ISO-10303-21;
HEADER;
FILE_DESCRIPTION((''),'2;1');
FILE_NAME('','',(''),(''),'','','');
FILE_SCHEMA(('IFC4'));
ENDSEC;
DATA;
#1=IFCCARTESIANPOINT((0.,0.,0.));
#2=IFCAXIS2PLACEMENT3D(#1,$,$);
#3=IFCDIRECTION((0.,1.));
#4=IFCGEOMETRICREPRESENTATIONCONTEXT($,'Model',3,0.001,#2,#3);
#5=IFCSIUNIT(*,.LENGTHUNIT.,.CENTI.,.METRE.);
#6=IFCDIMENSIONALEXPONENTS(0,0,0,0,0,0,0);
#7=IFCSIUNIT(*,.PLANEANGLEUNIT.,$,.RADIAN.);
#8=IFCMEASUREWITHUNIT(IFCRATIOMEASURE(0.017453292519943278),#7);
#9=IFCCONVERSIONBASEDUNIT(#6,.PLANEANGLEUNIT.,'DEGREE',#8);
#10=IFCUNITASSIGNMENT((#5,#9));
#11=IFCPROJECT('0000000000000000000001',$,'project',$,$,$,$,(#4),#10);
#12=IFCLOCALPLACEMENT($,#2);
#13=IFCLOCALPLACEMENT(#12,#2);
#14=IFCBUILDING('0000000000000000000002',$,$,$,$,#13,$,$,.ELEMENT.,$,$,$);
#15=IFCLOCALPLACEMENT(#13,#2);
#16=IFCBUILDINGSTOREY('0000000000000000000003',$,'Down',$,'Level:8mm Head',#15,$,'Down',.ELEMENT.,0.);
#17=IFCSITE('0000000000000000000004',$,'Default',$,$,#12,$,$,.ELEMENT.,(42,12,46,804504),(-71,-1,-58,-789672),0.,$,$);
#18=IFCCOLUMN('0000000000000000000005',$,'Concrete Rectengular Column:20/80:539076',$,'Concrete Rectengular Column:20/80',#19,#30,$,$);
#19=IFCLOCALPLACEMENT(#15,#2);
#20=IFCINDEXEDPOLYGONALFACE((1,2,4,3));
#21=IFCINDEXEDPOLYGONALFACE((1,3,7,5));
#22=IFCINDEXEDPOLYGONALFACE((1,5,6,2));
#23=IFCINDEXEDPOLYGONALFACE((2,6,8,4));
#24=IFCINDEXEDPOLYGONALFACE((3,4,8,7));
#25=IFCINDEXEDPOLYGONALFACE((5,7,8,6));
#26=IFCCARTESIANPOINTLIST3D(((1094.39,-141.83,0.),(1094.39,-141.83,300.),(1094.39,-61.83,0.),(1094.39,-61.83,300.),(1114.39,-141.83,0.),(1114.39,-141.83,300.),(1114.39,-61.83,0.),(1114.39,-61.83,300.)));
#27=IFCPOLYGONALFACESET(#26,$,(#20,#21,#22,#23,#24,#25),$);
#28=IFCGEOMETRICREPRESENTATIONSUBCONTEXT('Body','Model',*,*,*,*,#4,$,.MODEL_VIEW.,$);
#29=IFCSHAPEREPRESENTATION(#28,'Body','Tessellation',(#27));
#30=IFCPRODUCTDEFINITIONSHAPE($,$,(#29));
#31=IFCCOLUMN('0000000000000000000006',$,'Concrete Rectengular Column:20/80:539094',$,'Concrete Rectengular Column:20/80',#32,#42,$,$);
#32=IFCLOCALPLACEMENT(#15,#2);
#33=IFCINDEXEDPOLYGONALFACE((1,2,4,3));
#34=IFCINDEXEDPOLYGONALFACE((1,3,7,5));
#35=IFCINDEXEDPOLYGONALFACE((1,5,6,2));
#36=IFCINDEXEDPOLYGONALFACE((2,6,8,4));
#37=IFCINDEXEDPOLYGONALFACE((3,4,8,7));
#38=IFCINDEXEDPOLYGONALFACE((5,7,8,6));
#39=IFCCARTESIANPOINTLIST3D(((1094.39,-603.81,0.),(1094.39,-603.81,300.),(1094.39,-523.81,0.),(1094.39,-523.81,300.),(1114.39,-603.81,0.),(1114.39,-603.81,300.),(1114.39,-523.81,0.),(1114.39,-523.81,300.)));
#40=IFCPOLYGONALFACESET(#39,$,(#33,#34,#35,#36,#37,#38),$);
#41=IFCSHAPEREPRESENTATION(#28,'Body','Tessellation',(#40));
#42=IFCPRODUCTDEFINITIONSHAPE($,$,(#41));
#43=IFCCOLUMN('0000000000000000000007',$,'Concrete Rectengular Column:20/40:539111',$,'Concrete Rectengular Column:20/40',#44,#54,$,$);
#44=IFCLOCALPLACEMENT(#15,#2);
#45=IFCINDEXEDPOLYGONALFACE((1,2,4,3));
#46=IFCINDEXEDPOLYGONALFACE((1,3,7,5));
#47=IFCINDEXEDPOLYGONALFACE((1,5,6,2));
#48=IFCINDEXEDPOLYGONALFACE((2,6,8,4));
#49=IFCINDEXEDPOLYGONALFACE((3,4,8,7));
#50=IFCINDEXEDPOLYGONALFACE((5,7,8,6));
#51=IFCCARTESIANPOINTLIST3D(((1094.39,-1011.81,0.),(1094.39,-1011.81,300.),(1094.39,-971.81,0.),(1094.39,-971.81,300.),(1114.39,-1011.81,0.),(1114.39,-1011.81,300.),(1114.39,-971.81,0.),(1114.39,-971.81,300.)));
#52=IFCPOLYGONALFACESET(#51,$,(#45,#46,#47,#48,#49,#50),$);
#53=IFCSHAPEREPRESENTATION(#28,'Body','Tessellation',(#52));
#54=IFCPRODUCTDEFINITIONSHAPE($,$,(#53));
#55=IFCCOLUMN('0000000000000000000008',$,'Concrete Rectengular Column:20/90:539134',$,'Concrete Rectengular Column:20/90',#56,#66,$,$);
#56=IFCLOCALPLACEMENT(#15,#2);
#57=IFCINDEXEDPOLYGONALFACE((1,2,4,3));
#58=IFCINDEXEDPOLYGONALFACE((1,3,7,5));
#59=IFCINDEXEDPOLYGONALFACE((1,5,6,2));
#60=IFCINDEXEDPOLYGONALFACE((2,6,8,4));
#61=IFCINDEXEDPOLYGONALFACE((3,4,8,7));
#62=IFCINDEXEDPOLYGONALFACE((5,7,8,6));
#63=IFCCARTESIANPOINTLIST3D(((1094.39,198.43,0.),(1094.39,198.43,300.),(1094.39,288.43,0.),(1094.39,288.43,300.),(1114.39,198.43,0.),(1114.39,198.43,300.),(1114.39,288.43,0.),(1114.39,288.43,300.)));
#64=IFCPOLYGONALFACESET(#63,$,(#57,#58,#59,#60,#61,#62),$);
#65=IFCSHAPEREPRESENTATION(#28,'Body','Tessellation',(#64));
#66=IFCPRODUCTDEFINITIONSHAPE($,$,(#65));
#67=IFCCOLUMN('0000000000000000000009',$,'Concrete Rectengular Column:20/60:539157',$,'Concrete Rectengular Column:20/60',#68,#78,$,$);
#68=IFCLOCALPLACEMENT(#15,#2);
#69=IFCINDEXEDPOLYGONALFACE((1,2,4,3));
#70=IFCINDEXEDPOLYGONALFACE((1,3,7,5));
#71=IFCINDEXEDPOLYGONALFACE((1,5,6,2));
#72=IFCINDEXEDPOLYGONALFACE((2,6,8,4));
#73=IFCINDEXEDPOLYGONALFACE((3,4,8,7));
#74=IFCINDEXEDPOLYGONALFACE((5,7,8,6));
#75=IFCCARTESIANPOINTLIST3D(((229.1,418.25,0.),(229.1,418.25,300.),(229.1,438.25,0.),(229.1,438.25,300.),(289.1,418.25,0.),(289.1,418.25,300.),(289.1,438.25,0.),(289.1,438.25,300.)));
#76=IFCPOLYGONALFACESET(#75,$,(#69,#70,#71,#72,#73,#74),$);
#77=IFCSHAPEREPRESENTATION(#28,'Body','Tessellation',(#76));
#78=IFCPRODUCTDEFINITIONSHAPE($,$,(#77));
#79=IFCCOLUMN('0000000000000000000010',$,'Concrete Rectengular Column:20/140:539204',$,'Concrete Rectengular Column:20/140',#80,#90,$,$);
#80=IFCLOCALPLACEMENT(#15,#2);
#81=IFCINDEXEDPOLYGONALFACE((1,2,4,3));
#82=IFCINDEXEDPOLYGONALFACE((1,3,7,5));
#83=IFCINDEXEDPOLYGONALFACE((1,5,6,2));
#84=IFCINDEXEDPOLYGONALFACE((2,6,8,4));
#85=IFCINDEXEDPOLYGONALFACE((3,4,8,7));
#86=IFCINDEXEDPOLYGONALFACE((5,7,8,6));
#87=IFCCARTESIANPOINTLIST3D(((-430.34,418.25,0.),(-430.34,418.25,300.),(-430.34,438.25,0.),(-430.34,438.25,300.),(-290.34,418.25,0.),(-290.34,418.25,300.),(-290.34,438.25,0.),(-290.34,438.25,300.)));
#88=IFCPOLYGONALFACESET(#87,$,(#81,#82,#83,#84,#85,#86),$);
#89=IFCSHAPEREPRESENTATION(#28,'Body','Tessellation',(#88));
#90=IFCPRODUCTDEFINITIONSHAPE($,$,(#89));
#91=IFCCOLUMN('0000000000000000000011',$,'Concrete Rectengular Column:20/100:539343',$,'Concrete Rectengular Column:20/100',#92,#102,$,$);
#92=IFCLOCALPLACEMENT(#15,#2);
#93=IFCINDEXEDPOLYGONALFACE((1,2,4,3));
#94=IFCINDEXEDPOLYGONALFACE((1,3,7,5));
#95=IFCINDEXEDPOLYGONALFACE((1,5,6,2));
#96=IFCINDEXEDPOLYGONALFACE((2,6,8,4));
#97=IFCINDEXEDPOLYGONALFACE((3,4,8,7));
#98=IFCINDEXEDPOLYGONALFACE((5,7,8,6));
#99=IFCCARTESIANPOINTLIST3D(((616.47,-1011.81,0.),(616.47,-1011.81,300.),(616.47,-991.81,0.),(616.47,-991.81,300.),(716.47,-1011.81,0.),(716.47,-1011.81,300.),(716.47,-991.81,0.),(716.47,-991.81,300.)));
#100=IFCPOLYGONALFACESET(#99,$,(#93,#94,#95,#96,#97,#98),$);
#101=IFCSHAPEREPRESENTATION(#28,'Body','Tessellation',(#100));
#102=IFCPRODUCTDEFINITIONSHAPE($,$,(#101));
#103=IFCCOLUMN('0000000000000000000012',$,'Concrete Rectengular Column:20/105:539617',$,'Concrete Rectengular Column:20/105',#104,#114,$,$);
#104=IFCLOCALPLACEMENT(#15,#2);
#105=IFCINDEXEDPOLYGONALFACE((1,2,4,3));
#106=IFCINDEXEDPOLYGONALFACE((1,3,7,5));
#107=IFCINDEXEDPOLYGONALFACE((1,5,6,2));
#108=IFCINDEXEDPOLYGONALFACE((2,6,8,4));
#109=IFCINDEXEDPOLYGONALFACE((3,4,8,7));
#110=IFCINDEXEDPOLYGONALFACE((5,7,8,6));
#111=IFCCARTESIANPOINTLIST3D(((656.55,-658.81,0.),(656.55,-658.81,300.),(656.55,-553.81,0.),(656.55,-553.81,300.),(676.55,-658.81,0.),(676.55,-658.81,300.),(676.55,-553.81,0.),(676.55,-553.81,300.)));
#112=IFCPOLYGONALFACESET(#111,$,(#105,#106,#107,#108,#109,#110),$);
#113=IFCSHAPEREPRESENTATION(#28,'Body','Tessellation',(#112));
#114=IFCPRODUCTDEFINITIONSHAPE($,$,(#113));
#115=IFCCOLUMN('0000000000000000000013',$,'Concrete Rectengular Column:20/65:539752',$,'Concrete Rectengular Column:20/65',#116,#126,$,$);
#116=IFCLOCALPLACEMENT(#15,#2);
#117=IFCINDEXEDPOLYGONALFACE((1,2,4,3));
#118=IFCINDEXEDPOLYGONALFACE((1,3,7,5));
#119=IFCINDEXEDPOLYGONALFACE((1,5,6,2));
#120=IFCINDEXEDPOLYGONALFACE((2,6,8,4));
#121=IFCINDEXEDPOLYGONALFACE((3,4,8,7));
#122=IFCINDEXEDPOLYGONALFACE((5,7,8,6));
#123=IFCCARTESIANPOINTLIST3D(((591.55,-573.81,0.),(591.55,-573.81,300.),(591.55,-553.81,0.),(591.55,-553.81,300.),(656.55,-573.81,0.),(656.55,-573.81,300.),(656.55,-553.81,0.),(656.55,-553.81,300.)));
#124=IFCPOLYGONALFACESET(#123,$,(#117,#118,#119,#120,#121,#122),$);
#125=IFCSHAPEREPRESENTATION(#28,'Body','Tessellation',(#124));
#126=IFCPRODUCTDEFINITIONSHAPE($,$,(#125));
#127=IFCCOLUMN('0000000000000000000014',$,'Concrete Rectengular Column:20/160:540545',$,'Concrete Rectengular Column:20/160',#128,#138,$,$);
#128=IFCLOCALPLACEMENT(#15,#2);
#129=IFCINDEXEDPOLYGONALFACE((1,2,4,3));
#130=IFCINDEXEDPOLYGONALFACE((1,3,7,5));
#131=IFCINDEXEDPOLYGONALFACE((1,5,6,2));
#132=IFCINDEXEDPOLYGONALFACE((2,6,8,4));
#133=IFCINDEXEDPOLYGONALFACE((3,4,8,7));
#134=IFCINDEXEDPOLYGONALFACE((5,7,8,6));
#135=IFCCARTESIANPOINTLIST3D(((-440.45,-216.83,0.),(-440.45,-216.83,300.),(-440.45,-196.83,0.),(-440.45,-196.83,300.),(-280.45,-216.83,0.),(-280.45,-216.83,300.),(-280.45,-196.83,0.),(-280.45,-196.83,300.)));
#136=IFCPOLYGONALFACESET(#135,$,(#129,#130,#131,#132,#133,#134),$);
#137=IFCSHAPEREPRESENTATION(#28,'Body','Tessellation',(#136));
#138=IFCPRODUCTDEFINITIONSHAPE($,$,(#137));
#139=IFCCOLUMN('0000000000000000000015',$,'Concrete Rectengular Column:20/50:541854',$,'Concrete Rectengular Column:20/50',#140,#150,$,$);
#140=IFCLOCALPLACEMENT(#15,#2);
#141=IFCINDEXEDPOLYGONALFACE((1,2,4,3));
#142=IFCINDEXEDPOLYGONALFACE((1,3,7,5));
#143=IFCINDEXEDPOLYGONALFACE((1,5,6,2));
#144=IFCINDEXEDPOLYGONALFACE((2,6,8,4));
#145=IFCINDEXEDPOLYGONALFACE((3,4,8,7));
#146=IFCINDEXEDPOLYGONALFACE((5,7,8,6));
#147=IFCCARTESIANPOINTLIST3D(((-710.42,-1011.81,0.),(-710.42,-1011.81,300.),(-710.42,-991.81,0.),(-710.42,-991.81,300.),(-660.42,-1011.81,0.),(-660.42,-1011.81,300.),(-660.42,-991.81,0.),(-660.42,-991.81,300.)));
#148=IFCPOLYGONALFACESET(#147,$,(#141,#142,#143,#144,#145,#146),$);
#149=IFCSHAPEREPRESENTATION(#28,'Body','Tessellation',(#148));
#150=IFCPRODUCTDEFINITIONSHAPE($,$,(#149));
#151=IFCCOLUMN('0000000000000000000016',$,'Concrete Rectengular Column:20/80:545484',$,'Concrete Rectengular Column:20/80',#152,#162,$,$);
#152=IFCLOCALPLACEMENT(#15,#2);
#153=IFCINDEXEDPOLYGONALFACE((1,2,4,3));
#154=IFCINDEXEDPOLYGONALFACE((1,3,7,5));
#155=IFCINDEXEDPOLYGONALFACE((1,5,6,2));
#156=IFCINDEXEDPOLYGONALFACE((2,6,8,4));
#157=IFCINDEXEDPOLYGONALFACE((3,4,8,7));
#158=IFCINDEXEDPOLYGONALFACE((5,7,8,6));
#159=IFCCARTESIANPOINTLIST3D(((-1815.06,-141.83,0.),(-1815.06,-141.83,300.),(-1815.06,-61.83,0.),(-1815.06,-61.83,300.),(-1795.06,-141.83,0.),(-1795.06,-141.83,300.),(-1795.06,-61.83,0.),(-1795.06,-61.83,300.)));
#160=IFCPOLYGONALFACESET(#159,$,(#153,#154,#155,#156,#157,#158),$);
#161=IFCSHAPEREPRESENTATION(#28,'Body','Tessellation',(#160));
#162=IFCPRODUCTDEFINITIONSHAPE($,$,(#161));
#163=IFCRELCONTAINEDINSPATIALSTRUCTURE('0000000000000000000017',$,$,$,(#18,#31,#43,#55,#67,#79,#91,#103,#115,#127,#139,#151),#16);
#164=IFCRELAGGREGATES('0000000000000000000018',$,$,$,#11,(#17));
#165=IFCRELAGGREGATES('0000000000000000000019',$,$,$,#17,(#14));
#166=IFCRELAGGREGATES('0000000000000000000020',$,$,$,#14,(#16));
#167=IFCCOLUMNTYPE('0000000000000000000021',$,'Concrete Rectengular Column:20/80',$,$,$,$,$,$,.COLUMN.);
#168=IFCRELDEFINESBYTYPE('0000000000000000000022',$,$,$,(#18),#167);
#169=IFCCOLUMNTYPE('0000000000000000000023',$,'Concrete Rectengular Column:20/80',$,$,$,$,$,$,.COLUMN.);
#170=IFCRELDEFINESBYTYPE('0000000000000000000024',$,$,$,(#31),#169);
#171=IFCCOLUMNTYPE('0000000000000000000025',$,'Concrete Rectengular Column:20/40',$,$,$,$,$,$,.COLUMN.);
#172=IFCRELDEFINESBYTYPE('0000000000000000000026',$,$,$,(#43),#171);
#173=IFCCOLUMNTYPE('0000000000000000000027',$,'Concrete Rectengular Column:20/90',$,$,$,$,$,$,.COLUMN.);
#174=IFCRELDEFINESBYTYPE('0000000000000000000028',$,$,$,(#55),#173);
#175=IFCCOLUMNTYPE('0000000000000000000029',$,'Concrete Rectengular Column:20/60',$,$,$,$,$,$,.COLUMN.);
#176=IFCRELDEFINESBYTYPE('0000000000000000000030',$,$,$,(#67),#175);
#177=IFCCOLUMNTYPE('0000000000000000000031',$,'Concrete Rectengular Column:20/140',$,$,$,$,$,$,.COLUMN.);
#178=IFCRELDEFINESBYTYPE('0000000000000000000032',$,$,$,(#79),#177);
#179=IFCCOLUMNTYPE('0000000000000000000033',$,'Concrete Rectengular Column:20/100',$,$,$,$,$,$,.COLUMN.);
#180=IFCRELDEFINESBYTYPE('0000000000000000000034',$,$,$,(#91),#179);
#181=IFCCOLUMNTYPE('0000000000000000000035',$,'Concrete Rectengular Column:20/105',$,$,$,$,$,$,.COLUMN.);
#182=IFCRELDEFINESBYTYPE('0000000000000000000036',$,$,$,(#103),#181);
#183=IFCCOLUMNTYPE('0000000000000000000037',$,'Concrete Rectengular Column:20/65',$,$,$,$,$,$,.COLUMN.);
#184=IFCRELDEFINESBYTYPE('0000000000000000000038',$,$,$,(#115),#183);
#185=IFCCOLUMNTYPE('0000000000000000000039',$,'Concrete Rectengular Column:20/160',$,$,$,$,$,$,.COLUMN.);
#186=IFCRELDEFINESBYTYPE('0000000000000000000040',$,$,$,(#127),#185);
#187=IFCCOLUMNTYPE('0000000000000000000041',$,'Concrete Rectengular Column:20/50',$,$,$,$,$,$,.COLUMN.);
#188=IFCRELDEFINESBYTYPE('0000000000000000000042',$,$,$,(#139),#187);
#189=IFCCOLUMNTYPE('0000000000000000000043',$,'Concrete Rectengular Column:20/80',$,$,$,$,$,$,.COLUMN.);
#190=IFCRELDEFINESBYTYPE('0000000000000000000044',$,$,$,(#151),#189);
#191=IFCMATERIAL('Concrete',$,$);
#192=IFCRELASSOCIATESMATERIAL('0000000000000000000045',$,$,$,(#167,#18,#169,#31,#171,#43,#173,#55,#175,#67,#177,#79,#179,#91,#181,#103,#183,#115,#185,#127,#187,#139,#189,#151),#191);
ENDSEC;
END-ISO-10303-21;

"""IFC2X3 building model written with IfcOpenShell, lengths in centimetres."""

from ifc_helpers import new_model, entity, si_unit, converted_unit, direction, frame, frame_2d, origin, origin_2d_with_axis, place, context, subcontext, project, spatial, rectangle, extrude, source, transform, mapped, material, type_object, type_shapes, element, save


model = new_model("IFC2X3")

# Units and contexts
model_context = context("Model", 3, precision=0.001, world=origin(), true_north=direction((0.0, 1.0)))
body_context = subcontext(model_context, "Body", "Model", "MODEL_VIEW")
ifc_project = project(units=[si_unit("LENGTHUNIT", "METRE", prefix="CENTI"), converted_unit("PLANEANGLEUNIT", "DEGREE", entity("IfcRatioMeasure", 0.017453292519943278), si_unit("PLANEANGLEUNIT", "RADIAN"), dimensions=[0, 0, 0, 0, 0, 0, 0])], contexts=[model_context])

# Site, building, storey
site_placement = place(None, origin())
site = spatial("IfcSite", under=ifc_project, at=site_placement, Name="Default", CompositionType="ELEMENT", RefLatitude=(42, 12, 46, 804504), RefLongitude=(-71, -1, -58, -789672), RefElevation=0.0)
building_placement = place(site_placement, origin())
building = spatial("IfcBuilding", under=site, at=building_placement, CompositionType="ELEMENT")
storey_placement = place(building_placement, origin())
storey = spatial("IfcBuildingStorey", under=building, at=storey_placement, Name="Down", ObjectType="Level:8mm Head", LongName="Down", CompositionType="ELEMENT", Elevation=0.0)

# Columns
ifc_material = material(Name="Concrete")
column_type_1 = type_object("IfcColumnType", Name="Concrete Rectengular Column:20/80", PredefinedType="COLUMN", material=ifc_material)
shared_shape_1 = source(origin(), body_context, "Body", "SweptSolid", [
    extrude(rectangle(XDim=80.0, YDim=20.0, at=frame_2d((0.0, 0.0), x_axis=(1.0, 0.0))), frame((1104.39, -101.83, 0.0), z_axis=(0.0, 0.0, 1.0), x_axis=(0.0, -1.0, 0.0)), (0.0, 0.0, 1.0), 300.0),
])
type_shapes(column_type_1, [shared_shape_1])
column_1_placement = place(storey_placement, origin())
element("IfcColumn", 1, at=column_1_placement, inside=storey, type_object=column_type_1, material=ifc_material, Name="Concrete Rectengular Column:20/80:539076", ObjectType="Concrete Rectengular Column:20/80", context=body_context, shape_type="MappedRepresentation", body=[
    mapped(shared_shape_1, transform((0.0, 0.0, 0.0), scale=1.0)),
])
column_type_2 = type_object("IfcColumnType", Name="Concrete Rectengular Column:20/80", PredefinedType="COLUMN", material=ifc_material)
shared_shape_2 = source(origin(), body_context, "Body", "SweptSolid", [
    extrude(rectangle(XDim=80.0, YDim=20.0, at=frame_2d((0.0, 0.0), x_axis=(1.0, 0.0))), frame((1104.39, -563.81, 0.0), z_axis=(0.0, 0.0, 1.0), x_axis=(0.0, -1.0, 0.0)), (0.0, 0.0, 1.0), 300.0),
])
type_shapes(column_type_2, [shared_shape_2])
column_2_placement = place(storey_placement, origin())
element("IfcColumn", 2, at=column_2_placement, inside=storey, type_object=column_type_2, material=ifc_material, Name="Concrete Rectengular Column:20/80:539094", ObjectType="Concrete Rectengular Column:20/80", context=body_context, shape_type="MappedRepresentation", body=[
    mapped(shared_shape_2, transform((0.0, 0.0, 0.0), scale=1.0)),
])
column_type_3 = type_object("IfcColumnType", Name="Concrete Rectengular Column:20/40", PredefinedType="COLUMN", material=ifc_material)
shared_shape_3 = source(origin(), body_context, "Body", "SweptSolid", [
    extrude(rectangle(XDim=40.0, YDim=20.0, at=frame_2d((0.0, 0.0), x_axis=(1.0, 0.0))), frame((1104.39, -991.81, 0.0), z_axis=(0.0, 0.0, 1.0), x_axis=(0.0, -1.0, 0.0)), (0.0, 0.0, 1.0), 300.0),
])
type_shapes(column_type_3, [shared_shape_3])
column_3_placement = place(storey_placement, origin())
element("IfcColumn", 3, at=column_3_placement, inside=storey, type_object=column_type_3, material=ifc_material, Name="Concrete Rectengular Column:20/40:539111", ObjectType="Concrete Rectengular Column:20/40", context=body_context, shape_type="MappedRepresentation", body=[
    mapped(shared_shape_3, transform((0.0, 0.0, 0.0), scale=1.0)),
])
column_type_4 = type_object("IfcColumnType", Name="Concrete Rectengular Column:20/90", PredefinedType="COLUMN", material=ifc_material)
shared_shape_4 = source(origin(), body_context, "Body", "SweptSolid", [
    extrude(rectangle(XDim=90.0, YDim=20.0, at=frame_2d((0.0, 0.0), x_axis=(1.0, 0.0))), frame((1104.39, 243.43, 0.0), z_axis=(0.0, 0.0, 1.0), x_axis=(0.0, -1.0, 0.0)), (0.0, 0.0, 1.0), 300.0),
])
type_shapes(column_type_4, [shared_shape_4])
column_4_placement = place(storey_placement, origin())
element("IfcColumn", 4, at=column_4_placement, inside=storey, type_object=column_type_4, material=ifc_material, Name="Concrete Rectengular Column:20/90:539134", ObjectType="Concrete Rectengular Column:20/90", context=body_context, shape_type="MappedRepresentation", body=[
    mapped(shared_shape_4, transform((0.0, 0.0, 0.0), scale=1.0)),
])
column_type_5 = type_object("IfcColumnType", Name="Concrete Rectengular Column:20/60", PredefinedType="COLUMN", material=ifc_material)
shared_shape_5 = source(origin(), body_context, "Body", "SweptSolid", [
    extrude(rectangle(XDim=20.0, YDim=60.0, at=frame_2d((0.0, 0.0), x_axis=(1.0, 0.0))), frame((259.1, 428.25, 0.0), z_axis=(0.0, 0.0, 1.0), x_axis=(0.0, -1.0, 0.0)), (0.0, 0.0, 1.0), 300.0),
])
type_shapes(column_type_5, [shared_shape_5])
column_5_placement = place(storey_placement, origin())
element("IfcColumn", 5, at=column_5_placement, inside=storey, type_object=column_type_5, material=ifc_material, Name="Concrete Rectengular Column:20/60:539157", ObjectType="Concrete Rectengular Column:20/60", context=body_context, shape_type="MappedRepresentation", body=[
    mapped(shared_shape_5, transform((0.0, 0.0, 0.0), scale=1.0)),
])
column_type_6 = type_object("IfcColumnType", Name="Concrete Rectengular Column:20/140", PredefinedType="COLUMN", material=ifc_material)
shared_shape_6 = source(origin(), body_context, "Body", "SweptSolid", [
    extrude(rectangle(XDim=20.0, YDim=140.0, at=origin_2d_with_axis()), frame((-360.34, 428.25, 0.0), z_axis=(0.0, 0.0, 1.0), x_axis=(0.0, -1.0, 0.0)), (0.0, 0.0, 1.0), 300.0),
])
type_shapes(column_type_6, [shared_shape_6])
column_6_placement = place(storey_placement, origin())
element("IfcColumn", 6, at=column_6_placement, inside=storey, type_object=column_type_6, material=ifc_material, Name="Concrete Rectengular Column:20/140:539204", ObjectType="Concrete Rectengular Column:20/140", context=body_context, shape_type="MappedRepresentation", body=[
    mapped(shared_shape_6, transform((0.0, 0.0, 0.0), scale=1.0)),
])
column_type_7 = type_object("IfcColumnType", Name="Concrete Rectengular Column:20/100", PredefinedType="COLUMN", material=ifc_material)
shared_shape_7 = source(origin(), body_context, "Body", "SweptSolid", [
    extrude(rectangle(XDim=20.0, YDim=100.0, at=frame_2d((0.0, 0.0), x_axis=(1.0, 0.0))), frame((666.47, -1001.81, 0.0), z_axis=(0.0, 0.0, 1.0), x_axis=(0.0, -1.0, 0.0)), (0.0, 0.0, 1.0), 300.0),
])
type_shapes(column_type_7, [shared_shape_7])
column_7_placement = place(storey_placement, origin())
element("IfcColumn", 7, at=column_7_placement, inside=storey, type_object=column_type_7, material=ifc_material, Name="Concrete Rectengular Column:20/100:539343", ObjectType="Concrete Rectengular Column:20/100", context=body_context, shape_type="MappedRepresentation", body=[
    mapped(shared_shape_7, transform((0.0, 0.0, 0.0), scale=1.0)),
])
column_type_8 = type_object("IfcColumnType", Name="Concrete Rectengular Column:20/105", PredefinedType="COLUMN", material=ifc_material)
shared_shape_8 = source(origin(), body_context, "Body", "SweptSolid", [
    extrude(rectangle(XDim=105.0, YDim=20.0, at=origin_2d_with_axis()), frame((666.55, -606.31, 0.0), z_axis=(0.0, 0.0, 1.0), x_axis=(0.0, -1.0, 0.0)), (0.0, 0.0, 1.0), 300.0),
])
type_shapes(column_type_8, [shared_shape_8])
column_8_placement = place(storey_placement, origin())
element("IfcColumn", 8, at=column_8_placement, inside=storey, type_object=column_type_8, material=ifc_material, Name="Concrete Rectengular Column:20/105:539617", ObjectType="Concrete Rectengular Column:20/105", context=body_context, shape_type="MappedRepresentation", body=[
    mapped(shared_shape_8, transform((0.0, 0.0, 0.0), scale=1.0)),
])
column_type_9 = type_object("IfcColumnType", Name="Concrete Rectengular Column:20/65", PredefinedType="COLUMN", material=ifc_material)
shared_shape_9 = source(origin(), body_context, "Body", "SweptSolid", [
    extrude(rectangle(XDim=20.0, YDim=65.0, at=origin_2d_with_axis()), frame((624.05, -563.81, 0.0), z_axis=(0.0, 0.0, 1.0), x_axis=(0.0, -1.0, 0.0)), (0.0, 0.0, 1.0), 300.0),
])
type_shapes(column_type_9, [shared_shape_9])
column_9_placement = place(storey_placement, origin())
element("IfcColumn", 9, at=column_9_placement, inside=storey, type_object=column_type_9, material=ifc_material, Name="Concrete Rectengular Column:20/65:539752", ObjectType="Concrete Rectengular Column:20/65", context=body_context, shape_type="MappedRepresentation", body=[
    mapped(shared_shape_9, transform((0.0, 0.0, 0.0), scale=1.0)),
])
column_type_10 = type_object("IfcColumnType", Name="Concrete Rectengular Column:20/160", PredefinedType="COLUMN", material=ifc_material)
shared_shape_10 = source(origin(), body_context, "Body", "SweptSolid", [
    extrude(rectangle(XDim=20.0, YDim=160.0, at=origin_2d_with_axis()), frame((-360.45, -206.83, 0.0), z_axis=(0.0, 0.0, 1.0), x_axis=(0.0, -1.0, 0.0)), (0.0, 0.0, 1.0), 300.0),
])
type_shapes(column_type_10, [shared_shape_10])
column_10_placement = place(storey_placement, origin())
element("IfcColumn", 10, at=column_10_placement, inside=storey, type_object=column_type_10, material=ifc_material, Name="Concrete Rectengular Column:20/160:540545", ObjectType="Concrete Rectengular Column:20/160", context=body_context, shape_type="MappedRepresentation", body=[
    mapped(shared_shape_10, transform((0.0, 0.0, 0.0), scale=1.0)),
])
column_type_11 = type_object("IfcColumnType", Name="Concrete Rectengular Column:20/50", PredefinedType="COLUMN", material=ifc_material)
shared_shape_11 = source(origin(), body_context, "Body", "SweptSolid", [
    extrude(rectangle(XDim=20.0, YDim=50.0, at=frame_2d((0.0, 0.0), x_axis=(1.0, 0.0))), frame((-685.42, -1001.81, 0.0), z_axis=(0.0, 0.0, 1.0), x_axis=(0.0, -1.0, 0.0)), (0.0, 0.0, 1.0), 300.0),
])
type_shapes(column_type_11, [shared_shape_11])
column_11_placement = place(storey_placement, origin())
element("IfcColumn", 11, at=column_11_placement, inside=storey, type_object=column_type_11, material=ifc_material, Name="Concrete Rectengular Column:20/50:541854", ObjectType="Concrete Rectengular Column:20/50", context=body_context, shape_type="MappedRepresentation", body=[
    mapped(shared_shape_11, transform((0.0, 0.0, 0.0), scale=1.0)),
])
column_type_12 = type_object("IfcColumnType", Name="Concrete Rectengular Column:20/80", PredefinedType="COLUMN", material=ifc_material)
shared_shape_12 = source(origin(), body_context, "Body", "SweptSolid", [
    extrude(rectangle(XDim=80.0, YDim=20.0, at=frame_2d((0.0, 0.0), x_axis=(1.0, 0.0))), frame((-1805.06, -101.83, 0.0), z_axis=(0.0, 0.0, 1.0), x_axis=(0.0, -1.0, 0.0)), (0.0, 0.0, 1.0), 300.0),
])
type_shapes(column_type_12, [shared_shape_12])
column_12_placement = place(storey_placement, origin())
element("IfcColumn", 12, at=column_12_placement, inside=storey, type_object=column_type_12, material=ifc_material, Name="Concrete Rectengular Column:20/80:545484", ObjectType="Concrete Rectengular Column:20/80", context=body_context, shape_type="MappedRepresentation", body=[
    mapped(shared_shape_12, transform((0.0, 0.0, 0.0), scale=1.0)),
])

save(model, "model.ifc")
